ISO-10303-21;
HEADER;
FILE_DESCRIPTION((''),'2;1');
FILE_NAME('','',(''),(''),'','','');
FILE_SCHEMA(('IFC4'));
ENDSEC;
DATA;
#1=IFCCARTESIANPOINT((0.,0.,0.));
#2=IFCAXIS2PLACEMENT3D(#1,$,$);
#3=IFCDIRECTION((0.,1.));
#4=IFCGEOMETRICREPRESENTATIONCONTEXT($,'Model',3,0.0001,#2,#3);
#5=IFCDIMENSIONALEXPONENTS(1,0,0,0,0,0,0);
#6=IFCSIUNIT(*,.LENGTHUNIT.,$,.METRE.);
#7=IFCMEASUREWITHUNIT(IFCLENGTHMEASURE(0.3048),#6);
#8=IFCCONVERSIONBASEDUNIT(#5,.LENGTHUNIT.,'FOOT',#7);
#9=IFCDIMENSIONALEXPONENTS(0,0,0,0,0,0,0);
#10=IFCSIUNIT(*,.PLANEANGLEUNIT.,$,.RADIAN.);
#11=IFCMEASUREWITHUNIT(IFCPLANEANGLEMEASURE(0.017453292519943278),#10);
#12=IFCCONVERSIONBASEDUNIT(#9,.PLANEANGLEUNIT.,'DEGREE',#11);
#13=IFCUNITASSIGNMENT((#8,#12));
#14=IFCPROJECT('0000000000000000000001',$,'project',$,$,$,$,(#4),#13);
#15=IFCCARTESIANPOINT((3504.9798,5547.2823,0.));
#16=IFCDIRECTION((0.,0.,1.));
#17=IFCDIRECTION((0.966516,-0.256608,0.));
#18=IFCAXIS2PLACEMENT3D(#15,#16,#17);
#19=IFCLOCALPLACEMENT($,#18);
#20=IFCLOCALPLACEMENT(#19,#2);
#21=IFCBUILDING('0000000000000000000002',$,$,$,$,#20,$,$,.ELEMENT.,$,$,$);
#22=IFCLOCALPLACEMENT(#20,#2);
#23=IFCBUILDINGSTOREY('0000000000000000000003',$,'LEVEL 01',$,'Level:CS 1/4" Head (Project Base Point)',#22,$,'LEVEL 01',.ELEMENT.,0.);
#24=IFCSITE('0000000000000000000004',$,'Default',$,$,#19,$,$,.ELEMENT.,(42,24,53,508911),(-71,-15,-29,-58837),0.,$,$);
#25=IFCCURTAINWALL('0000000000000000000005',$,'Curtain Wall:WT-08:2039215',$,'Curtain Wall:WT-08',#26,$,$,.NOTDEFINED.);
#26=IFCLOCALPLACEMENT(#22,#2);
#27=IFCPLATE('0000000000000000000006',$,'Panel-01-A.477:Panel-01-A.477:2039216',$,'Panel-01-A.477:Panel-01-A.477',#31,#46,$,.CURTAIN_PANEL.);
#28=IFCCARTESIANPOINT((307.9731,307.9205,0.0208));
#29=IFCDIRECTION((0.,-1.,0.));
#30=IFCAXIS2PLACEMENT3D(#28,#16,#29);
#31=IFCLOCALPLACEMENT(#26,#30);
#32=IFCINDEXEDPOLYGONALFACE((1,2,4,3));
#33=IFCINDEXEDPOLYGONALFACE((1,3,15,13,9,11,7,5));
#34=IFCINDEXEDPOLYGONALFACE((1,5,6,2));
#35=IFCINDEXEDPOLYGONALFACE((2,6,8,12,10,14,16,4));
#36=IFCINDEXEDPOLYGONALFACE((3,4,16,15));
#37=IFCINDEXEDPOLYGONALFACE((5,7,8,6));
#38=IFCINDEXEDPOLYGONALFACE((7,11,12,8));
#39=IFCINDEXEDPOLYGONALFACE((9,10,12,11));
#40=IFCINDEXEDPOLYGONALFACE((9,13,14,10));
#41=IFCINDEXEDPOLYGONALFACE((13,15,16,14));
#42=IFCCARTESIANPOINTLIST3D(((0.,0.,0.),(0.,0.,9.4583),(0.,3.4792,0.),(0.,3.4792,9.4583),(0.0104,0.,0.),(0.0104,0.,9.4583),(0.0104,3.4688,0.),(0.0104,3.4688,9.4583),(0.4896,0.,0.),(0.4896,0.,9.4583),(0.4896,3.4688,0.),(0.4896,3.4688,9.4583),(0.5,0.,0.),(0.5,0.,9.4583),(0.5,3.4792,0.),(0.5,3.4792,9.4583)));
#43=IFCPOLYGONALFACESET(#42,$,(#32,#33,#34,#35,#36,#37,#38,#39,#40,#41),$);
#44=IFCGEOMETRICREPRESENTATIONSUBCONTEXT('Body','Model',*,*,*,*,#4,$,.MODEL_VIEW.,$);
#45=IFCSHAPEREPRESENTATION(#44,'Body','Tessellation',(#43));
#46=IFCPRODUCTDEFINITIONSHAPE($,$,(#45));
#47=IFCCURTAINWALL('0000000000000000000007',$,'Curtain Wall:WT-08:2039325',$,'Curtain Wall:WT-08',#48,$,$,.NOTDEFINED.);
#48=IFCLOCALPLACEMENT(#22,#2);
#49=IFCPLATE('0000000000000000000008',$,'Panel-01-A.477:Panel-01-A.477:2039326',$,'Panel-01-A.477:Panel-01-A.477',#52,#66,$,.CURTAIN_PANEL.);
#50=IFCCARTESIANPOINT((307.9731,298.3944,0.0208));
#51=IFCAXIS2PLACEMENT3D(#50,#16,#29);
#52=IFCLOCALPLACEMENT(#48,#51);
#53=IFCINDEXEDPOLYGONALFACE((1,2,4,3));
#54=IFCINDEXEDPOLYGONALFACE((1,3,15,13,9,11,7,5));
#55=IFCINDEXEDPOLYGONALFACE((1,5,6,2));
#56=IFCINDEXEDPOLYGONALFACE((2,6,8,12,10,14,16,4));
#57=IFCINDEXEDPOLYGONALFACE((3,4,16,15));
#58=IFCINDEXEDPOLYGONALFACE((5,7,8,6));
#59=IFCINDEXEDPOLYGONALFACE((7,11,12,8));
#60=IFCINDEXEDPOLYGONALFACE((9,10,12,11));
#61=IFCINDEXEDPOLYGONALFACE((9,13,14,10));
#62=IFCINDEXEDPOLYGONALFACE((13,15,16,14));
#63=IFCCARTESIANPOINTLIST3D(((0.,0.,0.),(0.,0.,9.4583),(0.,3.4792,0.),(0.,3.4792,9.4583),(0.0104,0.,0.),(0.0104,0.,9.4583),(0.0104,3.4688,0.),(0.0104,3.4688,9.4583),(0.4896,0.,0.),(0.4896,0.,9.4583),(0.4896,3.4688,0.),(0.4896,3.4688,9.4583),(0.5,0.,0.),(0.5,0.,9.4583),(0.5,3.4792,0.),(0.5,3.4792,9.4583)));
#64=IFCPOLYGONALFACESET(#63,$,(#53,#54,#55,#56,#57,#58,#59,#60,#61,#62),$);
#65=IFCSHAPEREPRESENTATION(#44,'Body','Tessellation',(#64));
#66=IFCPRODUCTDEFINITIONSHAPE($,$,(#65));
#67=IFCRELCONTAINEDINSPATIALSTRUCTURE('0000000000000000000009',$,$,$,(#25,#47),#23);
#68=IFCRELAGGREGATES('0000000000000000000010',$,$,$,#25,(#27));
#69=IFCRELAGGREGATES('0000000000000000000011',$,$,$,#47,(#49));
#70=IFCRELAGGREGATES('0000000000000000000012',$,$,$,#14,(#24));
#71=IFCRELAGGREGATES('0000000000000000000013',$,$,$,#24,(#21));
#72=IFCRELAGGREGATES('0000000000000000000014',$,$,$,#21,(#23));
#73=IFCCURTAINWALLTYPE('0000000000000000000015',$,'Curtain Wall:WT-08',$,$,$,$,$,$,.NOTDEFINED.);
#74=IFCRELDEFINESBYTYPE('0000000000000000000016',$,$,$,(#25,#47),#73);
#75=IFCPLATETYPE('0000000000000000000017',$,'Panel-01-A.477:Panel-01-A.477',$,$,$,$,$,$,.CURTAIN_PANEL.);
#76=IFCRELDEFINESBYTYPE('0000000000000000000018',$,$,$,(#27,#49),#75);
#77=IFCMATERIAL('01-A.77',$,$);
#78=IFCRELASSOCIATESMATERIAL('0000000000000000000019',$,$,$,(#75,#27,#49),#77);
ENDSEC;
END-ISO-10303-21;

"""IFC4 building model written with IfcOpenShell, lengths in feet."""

from ifc_helpers import new_model, entity, si_unit, converted_unit, direction, frame, origin, place, context, subcontext, project, spatial, indexed_curve, outline, extrude, source, transform, mapped, material, type_object, type_shapes, element, aggregate, save


model = new_model("IFC4")

# Units and contexts
model_context = context("Model", 3, precision=0.0001, world=origin(), true_north=direction((0.0, 1.0)))
body_context = subcontext(model_context, "Body", "Model", "MODEL_VIEW")
ifc_project = project(units=[converted_unit("LENGTHUNIT", "FOOT", entity("IfcLengthMeasure", 0.3048), si_unit("LENGTHUNIT", "METRE"), dimensions=[1, 0, 0, 0, 0, 0, 0]), converted_unit("PLANEANGLEUNIT", "DEGREE", entity("IfcPlaneAngleMeasure", 0.017453292519943278), si_unit("PLANEANGLEUNIT", "RADIAN"), dimensions=[0, 0, 0, 0, 0, 0, 0])], contexts=[model_context])

# Site, building, storey
site_placement = place(None, frame((3504.9798, 5547.2823, 0.0), z_axis=(0.0, 0.0, 1.0), x_axis=(0.966516, -0.256608, 0.0)))
site = spatial("IfcSite", under=ifc_project, at=site_placement, Name="Default", CompositionType="ELEMENT", RefLatitude=(42, 24, 53, 508911), RefLongitude=(-71, -15, -29, -58837), RefElevation=0.0)
building_placement = place(site_placement, origin())
building = spatial("IfcBuilding", under=site, at=building_placement, CompositionType="ELEMENT")
storey_placement = place(building_placement, origin())
storey = spatial("IfcBuildingStorey", under=building, at=storey_placement, Name="LEVEL 01", ObjectType="Level:CS 1/4\" Head (Project Base Point)", LongName="LEVEL 01", CompositionType="ELEMENT", Elevation=0.0)

# Shared definitions
curtain_wall_type_1 = type_object("IfcCurtainWallType", Name="Curtain Wall:WT-08", PredefinedType="NOTDEFINED")

# Curtain walls, plates
curtain_wall_1_placement = place(storey_placement, origin())
curtain_wall_1 = element("IfcCurtainWall", 1, at=curtain_wall_1_placement, inside=storey, type_object=curtain_wall_type_1, Name="Curtain Wall:WT-08:2039215", ObjectType="Curtain Wall:WT-08", PredefinedType="NOTDEFINED")
ifc_material_1 = material(Name="01-A.77")
plate_type_1 = type_object("IfcPlateType", Name="Panel-01-A.477:Panel-01-A.477", PredefinedType="CURTAIN_PANEL", material=ifc_material_1)
shared_shape_1 = source(origin(), body_context, "Body", "SweptSolid", [
    extrude(outline(indexed_curve([(-0.25, -1.7422), (0.25, -1.7422), (0.25, 1.737), (0.2396, 1.737), (0.2396, -1.7318), (-0.2396, -1.7318), (-0.2396, 1.737), (-0.25, 1.737), (-0.25, -1.7422)], self_intersect=False)), frame((0.25, 1.737, 0.0), z_axis=(0.0, 0.0, 1.0), x_axis=(-1.0, 0.0, 0.0)), (0.0, 0.0, 1.0), 9.4583),
])
type_shapes(plate_type_1, [shared_shape_1])
plate_1_placement = place(curtain_wall_1_placement, frame((307.9731, 307.9205, 0.0208), z_axis=(0.0, 0.0, 1.0), x_axis=(0.0, -1.0, 0.0)))
plate_1 = element("IfcPlate", 2, at=plate_1_placement, type_object=plate_type_1, material=ifc_material_1, Name="Panel-01-A.477:Panel-01-A.477:2039216", ObjectType="Panel-01-A.477:Panel-01-A.477", PredefinedType="CURTAIN_PANEL", context=body_context, shape_type="MappedRepresentation", body=[
    mapped(shared_shape_1, transform((0.0, 0.0, 0.0), scale=1.0)),
])
aggregate(curtain_wall_1, [plate_1])
curtain_wall_2_placement = place(storey_placement, origin())
curtain_wall_2 = element("IfcCurtainWall", 3, at=curtain_wall_2_placement, inside=storey, type_object=curtain_wall_type_1, Name="Curtain Wall:WT-08:2039325", ObjectType="Curtain Wall:WT-08", PredefinedType="NOTDEFINED")
plate_2_placement = place(curtain_wall_2_placement, frame((307.9731, 298.3944, 0.0208), z_axis=(0.0, 0.0, 1.0), x_axis=(0.0, -1.0, 0.0)))
plate_2 = element("IfcPlate", 4, at=plate_2_placement, type_object=plate_type_1, material=ifc_material_1, Name="Panel-01-A.477:Panel-01-A.477:2039326", ObjectType="Panel-01-A.477:Panel-01-A.477", PredefinedType="CURTAIN_PANEL", context=body_context, shape_type="MappedRepresentation", body=[
    mapped(shared_shape_1, transform((0.0, 0.0, 0.0), scale=1.0)),
])
aggregate(curtain_wall_2, [plate_2])

save(model, "model.ifc")
